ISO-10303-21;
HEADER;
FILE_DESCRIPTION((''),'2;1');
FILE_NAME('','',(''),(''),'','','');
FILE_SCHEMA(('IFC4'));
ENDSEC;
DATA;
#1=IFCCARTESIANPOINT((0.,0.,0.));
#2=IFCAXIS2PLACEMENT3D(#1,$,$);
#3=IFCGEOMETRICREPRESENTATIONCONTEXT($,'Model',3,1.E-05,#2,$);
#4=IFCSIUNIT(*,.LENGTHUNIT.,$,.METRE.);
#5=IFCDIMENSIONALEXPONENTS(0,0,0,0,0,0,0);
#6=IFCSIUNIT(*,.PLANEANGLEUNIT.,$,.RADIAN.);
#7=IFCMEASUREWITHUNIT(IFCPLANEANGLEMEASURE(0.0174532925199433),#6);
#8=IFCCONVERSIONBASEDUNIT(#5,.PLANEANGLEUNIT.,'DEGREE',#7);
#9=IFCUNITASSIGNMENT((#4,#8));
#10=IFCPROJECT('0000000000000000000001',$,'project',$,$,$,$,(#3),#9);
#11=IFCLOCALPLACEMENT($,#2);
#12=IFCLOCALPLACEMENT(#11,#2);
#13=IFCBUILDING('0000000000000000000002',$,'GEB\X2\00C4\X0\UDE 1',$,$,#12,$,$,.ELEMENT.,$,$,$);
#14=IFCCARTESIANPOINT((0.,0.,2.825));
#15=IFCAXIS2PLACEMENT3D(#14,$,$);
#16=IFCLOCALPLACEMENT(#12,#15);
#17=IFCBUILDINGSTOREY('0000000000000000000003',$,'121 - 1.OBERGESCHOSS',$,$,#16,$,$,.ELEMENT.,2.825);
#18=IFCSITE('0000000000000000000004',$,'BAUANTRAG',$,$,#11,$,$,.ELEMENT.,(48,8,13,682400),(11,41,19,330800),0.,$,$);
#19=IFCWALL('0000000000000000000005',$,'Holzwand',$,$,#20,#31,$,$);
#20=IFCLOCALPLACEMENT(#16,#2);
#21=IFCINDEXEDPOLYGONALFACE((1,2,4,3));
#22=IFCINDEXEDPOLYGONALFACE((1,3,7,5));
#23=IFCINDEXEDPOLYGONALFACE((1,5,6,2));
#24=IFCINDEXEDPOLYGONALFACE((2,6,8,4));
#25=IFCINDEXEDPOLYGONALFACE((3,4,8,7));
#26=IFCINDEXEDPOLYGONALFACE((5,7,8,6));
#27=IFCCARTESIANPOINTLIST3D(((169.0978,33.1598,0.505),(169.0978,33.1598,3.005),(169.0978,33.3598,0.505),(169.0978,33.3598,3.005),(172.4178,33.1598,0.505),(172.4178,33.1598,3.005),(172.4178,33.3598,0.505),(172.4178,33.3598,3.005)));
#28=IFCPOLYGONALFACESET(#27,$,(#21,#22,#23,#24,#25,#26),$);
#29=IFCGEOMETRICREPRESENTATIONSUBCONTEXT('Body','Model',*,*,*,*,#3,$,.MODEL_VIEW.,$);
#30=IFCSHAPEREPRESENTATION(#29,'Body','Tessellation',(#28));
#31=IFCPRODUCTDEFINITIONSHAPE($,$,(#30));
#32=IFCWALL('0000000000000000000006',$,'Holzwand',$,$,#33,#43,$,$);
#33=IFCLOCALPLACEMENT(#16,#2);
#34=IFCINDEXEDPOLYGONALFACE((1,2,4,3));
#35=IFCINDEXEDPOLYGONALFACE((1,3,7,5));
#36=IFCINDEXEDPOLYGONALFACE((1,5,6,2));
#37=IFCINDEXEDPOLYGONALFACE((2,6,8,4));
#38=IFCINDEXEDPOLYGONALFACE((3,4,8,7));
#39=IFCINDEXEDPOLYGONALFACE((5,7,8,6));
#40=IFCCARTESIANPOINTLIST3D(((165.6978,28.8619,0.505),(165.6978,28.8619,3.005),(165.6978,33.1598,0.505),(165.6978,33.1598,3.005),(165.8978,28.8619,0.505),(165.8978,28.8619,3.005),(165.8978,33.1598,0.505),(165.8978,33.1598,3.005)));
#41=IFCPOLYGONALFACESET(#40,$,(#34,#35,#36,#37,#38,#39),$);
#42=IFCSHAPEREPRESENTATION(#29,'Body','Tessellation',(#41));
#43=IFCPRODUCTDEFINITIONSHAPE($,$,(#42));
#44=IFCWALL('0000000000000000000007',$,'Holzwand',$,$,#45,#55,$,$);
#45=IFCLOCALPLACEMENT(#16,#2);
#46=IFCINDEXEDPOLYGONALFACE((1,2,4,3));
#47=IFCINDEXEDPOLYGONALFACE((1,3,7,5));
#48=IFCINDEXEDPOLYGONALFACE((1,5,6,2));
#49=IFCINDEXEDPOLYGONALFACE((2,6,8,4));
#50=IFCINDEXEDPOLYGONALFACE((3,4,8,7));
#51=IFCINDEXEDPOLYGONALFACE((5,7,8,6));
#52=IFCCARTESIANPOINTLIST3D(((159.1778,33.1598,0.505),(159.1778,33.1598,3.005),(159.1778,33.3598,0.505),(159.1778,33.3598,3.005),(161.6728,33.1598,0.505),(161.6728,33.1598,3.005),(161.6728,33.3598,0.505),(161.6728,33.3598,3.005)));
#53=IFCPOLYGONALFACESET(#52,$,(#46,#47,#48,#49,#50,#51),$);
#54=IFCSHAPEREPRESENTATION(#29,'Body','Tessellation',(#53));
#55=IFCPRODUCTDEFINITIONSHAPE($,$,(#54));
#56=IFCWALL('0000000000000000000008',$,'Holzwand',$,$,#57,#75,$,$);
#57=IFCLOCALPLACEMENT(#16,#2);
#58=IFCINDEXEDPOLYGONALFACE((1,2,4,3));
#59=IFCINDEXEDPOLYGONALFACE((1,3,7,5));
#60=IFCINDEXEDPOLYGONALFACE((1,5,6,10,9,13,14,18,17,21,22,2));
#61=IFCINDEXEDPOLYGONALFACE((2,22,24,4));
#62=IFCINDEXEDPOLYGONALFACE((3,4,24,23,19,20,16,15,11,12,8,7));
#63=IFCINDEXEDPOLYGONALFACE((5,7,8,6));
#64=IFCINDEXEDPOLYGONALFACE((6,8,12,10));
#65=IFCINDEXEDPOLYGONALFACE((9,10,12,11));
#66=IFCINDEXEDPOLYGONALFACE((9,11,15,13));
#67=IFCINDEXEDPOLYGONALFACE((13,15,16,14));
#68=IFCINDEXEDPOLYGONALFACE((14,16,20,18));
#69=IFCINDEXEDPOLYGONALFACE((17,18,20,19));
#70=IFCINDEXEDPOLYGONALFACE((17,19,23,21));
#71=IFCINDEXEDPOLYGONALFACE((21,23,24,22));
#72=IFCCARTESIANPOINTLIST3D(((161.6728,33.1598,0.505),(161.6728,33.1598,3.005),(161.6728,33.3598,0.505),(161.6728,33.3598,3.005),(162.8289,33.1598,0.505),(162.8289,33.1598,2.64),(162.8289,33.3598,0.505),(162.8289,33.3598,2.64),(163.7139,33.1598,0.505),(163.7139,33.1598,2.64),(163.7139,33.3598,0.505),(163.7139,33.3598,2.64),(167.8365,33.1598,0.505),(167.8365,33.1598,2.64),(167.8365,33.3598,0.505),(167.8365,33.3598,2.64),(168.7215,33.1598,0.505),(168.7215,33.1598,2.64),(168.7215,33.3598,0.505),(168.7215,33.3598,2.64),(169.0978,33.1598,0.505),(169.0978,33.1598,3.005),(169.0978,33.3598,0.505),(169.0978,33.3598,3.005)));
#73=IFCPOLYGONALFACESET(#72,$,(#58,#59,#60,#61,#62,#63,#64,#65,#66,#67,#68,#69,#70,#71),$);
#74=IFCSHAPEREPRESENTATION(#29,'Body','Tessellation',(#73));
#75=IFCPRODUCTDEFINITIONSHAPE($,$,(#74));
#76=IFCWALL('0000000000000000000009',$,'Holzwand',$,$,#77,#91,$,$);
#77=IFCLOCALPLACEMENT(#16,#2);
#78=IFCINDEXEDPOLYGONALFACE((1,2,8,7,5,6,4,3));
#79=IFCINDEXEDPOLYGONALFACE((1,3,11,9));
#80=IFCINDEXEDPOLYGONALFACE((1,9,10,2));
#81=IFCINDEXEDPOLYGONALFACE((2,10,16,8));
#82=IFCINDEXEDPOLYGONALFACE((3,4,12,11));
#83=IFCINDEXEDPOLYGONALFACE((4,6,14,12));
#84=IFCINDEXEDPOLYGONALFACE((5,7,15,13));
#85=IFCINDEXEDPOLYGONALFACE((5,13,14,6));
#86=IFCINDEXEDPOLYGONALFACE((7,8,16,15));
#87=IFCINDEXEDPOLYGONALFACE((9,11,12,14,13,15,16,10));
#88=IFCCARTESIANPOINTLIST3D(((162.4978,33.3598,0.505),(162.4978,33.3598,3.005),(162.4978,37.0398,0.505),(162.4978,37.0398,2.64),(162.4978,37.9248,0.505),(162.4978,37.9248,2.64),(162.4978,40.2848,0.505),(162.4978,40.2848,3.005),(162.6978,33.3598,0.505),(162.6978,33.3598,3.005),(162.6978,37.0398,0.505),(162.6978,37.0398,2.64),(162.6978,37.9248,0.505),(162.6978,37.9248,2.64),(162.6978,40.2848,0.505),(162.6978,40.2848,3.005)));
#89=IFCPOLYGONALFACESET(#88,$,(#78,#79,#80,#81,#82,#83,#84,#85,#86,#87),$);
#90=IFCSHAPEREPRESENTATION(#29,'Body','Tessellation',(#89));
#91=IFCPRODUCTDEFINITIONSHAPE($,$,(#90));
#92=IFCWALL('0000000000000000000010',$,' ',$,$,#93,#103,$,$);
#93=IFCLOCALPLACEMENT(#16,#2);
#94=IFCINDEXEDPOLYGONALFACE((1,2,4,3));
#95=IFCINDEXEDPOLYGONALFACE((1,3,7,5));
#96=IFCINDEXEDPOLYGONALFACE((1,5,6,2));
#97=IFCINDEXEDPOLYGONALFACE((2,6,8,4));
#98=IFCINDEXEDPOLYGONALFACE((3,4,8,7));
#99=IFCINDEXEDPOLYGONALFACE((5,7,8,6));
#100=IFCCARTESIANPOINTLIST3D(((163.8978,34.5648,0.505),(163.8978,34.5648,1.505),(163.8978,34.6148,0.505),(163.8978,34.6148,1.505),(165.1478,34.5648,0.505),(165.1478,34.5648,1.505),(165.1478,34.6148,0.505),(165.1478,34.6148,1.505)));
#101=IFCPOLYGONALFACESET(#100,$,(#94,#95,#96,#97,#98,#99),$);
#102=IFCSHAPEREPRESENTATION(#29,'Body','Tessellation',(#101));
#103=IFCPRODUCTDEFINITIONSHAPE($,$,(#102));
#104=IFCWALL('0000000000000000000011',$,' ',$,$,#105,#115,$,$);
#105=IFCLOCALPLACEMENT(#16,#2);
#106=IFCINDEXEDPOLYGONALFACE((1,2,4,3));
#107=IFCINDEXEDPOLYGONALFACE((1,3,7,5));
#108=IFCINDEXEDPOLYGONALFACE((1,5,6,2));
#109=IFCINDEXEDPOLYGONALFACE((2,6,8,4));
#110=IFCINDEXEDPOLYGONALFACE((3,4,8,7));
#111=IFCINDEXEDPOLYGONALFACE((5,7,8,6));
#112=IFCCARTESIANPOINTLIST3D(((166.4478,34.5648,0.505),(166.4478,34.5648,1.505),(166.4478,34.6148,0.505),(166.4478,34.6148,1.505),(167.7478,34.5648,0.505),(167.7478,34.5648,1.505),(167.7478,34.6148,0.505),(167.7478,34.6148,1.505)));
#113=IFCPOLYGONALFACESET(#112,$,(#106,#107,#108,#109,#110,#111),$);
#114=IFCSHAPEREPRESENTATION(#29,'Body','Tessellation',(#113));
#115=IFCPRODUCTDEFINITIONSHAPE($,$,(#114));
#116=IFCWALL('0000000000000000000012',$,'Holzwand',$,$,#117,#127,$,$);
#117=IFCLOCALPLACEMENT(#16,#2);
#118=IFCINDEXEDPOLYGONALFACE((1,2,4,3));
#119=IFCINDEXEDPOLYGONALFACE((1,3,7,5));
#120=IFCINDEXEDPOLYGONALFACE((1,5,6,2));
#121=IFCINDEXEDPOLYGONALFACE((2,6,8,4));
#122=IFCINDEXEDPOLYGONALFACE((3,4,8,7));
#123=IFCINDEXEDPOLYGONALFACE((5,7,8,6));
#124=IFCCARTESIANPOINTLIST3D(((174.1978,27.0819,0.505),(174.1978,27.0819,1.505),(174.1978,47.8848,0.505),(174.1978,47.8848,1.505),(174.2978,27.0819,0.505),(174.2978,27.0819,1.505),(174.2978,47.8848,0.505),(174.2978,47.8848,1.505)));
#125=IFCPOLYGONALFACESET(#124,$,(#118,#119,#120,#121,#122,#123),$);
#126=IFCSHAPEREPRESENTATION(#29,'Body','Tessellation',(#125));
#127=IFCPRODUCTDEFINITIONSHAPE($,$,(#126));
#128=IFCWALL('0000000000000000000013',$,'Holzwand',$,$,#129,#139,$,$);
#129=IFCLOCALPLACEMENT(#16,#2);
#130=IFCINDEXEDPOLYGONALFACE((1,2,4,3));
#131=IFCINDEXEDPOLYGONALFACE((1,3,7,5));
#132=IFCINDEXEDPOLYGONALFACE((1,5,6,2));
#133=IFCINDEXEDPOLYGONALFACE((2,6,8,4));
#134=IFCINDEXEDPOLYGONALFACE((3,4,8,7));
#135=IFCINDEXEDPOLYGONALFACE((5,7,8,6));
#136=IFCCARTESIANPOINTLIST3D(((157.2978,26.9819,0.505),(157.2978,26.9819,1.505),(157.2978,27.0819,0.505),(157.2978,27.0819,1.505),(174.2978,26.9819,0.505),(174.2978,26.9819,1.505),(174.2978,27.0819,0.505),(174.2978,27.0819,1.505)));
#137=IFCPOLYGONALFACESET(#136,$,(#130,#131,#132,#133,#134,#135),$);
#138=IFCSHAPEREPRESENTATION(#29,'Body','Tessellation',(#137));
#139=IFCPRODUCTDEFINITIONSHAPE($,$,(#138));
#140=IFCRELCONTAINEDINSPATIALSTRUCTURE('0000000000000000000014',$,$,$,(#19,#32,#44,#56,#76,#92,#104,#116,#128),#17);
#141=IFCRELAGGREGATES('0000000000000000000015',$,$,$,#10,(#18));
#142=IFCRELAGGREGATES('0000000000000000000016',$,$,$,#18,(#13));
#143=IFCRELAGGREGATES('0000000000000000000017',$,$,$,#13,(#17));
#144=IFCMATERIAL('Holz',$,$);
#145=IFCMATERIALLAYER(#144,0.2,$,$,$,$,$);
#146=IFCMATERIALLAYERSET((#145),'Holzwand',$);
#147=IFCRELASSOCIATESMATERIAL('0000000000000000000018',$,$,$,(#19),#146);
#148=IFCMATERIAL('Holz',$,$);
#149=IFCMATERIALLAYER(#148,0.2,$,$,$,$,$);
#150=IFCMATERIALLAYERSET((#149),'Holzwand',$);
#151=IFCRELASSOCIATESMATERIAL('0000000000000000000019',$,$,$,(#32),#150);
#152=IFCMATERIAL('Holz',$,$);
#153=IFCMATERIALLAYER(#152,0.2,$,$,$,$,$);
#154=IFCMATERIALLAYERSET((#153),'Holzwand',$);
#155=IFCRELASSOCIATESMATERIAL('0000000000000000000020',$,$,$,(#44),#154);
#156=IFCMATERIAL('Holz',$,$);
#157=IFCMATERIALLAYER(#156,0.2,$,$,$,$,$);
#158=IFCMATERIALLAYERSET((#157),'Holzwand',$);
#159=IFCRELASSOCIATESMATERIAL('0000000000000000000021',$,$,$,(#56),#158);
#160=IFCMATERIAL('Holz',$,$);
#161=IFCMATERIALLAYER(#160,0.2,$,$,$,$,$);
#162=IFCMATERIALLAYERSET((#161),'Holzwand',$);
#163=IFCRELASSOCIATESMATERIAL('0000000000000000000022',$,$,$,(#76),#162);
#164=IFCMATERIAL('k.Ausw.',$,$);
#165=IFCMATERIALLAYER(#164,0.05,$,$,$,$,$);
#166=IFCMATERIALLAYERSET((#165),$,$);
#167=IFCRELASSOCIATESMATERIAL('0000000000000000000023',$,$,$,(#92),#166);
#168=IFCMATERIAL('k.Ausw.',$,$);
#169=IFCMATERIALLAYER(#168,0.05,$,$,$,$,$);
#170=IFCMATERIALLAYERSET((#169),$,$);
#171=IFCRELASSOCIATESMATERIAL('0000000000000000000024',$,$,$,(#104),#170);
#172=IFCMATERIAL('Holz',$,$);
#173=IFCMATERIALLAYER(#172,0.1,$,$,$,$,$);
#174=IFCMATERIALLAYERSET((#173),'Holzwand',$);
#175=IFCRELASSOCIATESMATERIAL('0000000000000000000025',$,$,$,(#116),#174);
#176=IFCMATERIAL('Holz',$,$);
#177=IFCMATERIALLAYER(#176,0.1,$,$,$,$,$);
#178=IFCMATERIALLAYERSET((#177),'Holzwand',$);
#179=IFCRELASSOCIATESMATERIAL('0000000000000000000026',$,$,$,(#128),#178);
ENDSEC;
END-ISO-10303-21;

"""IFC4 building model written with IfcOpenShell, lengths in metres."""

from ifc_helpers import new_model, entity, si_unit, converted_unit, frame, frame_2d, origin, origin_with_axes, place, context, subcontext, project, spatial, polyline, rectangle, outline, extrude, material, layer, layer_set, layer_usage, element, save


model = new_model("IFC4")

# Units and contexts
model_context = context("Model", 3, precision=1e-05, world=origin())
body_context = subcontext(model_context, "Body", "Model", "MODEL_VIEW")
ifc_project = project(units=[si_unit("LENGTHUNIT", "METRE"), converted_unit("PLANEANGLEUNIT", "DEGREE", entity("IfcPlaneAngleMeasure", 0.0174532925199433), si_unit("PLANEANGLEUNIT", "RADIAN"), dimensions=[0, 0, 0, 0, 0, 0, 0])], contexts=[model_context])

# Site, building, storey
site_placement = place(None, origin())
site = spatial("IfcSite", under=ifc_project, at=site_placement, Name="BAUANTRAG", CompositionType="ELEMENT", RefLatitude=(48, 8, 13, 682400), RefLongitude=(11, 41, 19, 330800), RefElevation=0.0)
building_placement = place(site_placement, origin())
building = spatial("IfcBuilding", under=site, at=building_placement, Name="GEBÄUDE 1", CompositionType="ELEMENT")
storey_placement = place(building_placement, frame((0.0, 0.0, 2.825)))
storey = spatial("IfcBuildingStorey", under=building, at=storey_placement, Name="121 - 1.OBERGESCHOSS", CompositionType="ELEMENT", Elevation=2.825)

# Walls
ifc_material_1 = material(Name="Holz")
ifc_layer_1 = layer(ifc_material_1, 0.2)
ifc_layer_set_1 = layer_set([ifc_layer_1], Name="Holzwand")
ifc_layer_usage_1 = layer_usage(ifc_layer_set_1, "AXIS2", "POSITIVE", 0.0)
wall_1_placement = place(storey_placement, frame((169.0978, 33.1598, 0.505)))
element("IfcWall", 1, at=wall_1_placement, inside=storey, material=ifc_layer_usage_1, Name="Holzwand", context=body_context, shape_type="SweptSolid", body=[
    extrude(rectangle(XDim=3.32, YDim=0.2, at=frame_2d((1.66, 0.1), x_axis=(1.0, 0.0))), origin_with_axes(), (0.0, 0.0, 1.0), 2.5),
])
ifc_material_2 = material(Name="Holz")
ifc_layer_2 = layer(ifc_material_2, 0.2)
ifc_layer_set_2 = layer_set([ifc_layer_2], Name="Holzwand")
ifc_layer_usage_2 = layer_usage(ifc_layer_set_2, "AXIS2", "POSITIVE", 0.0)
wall_2_placement = place(storey_placement, frame((165.6978, 33.1598, 0.505), z_axis=(0.0, 0.0, 1.0), x_axis=(0.0, -1.0, 0.0)))
element("IfcWall", 2, at=wall_2_placement, inside=storey, material=ifc_layer_usage_2, Name="Holzwand", context=body_context, shape_type="SweptSolid", body=[
    extrude(rectangle(XDim=4.2979, YDim=0.2, at=frame_2d((2.1489, 0.1), x_axis=(1.0, 0.0))), origin_with_axes(), (0.0, 0.0, 1.0), 2.5),
])
ifc_material_3 = material(Name="Holz")
ifc_layer_3 = layer(ifc_material_3, 0.2)
ifc_layer_set_3 = layer_set([ifc_layer_3], Name="Holzwand")
ifc_layer_usage_3 = layer_usage(ifc_layer_set_3, "AXIS2", "POSITIVE", 0.0)
wall_3_placement = place(storey_placement, frame((159.1778, 33.1598, 0.505)))
element("IfcWall", 3, at=wall_3_placement, inside=storey, material=ifc_layer_usage_3, Name="Holzwand", context=body_context, shape_type="SweptSolid", body=[
    extrude(rectangle(XDim=2.495, YDim=0.2, at=frame_2d((1.2475, 0.1), x_axis=(1.0, 0.0))), origin_with_axes(), (0.0, 0.0, 1.0), 2.5),
])

# Wall, openings
ifc_material_4 = material(Name="Holz")
ifc_layer_4 = layer(ifc_material_4, 0.2)
ifc_layer_set_4 = layer_set([ifc_layer_4], Name="Holzwand")
ifc_layer_usage_4 = layer_usage(ifc_layer_set_4, "AXIS2", "POSITIVE", 0.0)
wall_4_placement = place(storey_placement, frame((169.0978, 33.3598, 0.505), z_axis=(0.0, 0.0, 1.0), x_axis=(-1.0, 0.0, 0.0)))
wall_4 = element("IfcWall", 4, at=wall_4_placement, inside=storey, material=ifc_layer_usage_4, Name="Holzwand", context=body_context, shape_type="SweptSolid", body=[
    extrude(rectangle(XDim=7.425, YDim=0.2, at=frame_2d((3.7125, 0.1), x_axis=(1.0, 0.0))), origin_with_axes(), (0.0, 0.0, 1.0), 2.5),
])
opening_1_placement = place(wall_4_placement, frame((1.2613, 0.2, -0.15), z_axis=(0.0, -1.0, 0.0), x_axis=(0.0, 0.0, 1.0)))
element("IfcOpeningElement", 5, at=opening_1_placement, cuts=wall_4, ObjectType="Opening", context=body_context, shape_type="SweptSolid", body=[
    extrude(outline(polyline([(0.0, 0.885), (2.285, 0.885), (2.285, 0.0), (0.0, 0.0), (0.0, 0.885)])), origin_with_axes(), (0.0, 0.0, 1.0), 0.2),
])
opening_2_placement = place(wall_4_placement, frame((6.2689, 0.2, -0.15), z_axis=(0.0, -1.0, 0.0), x_axis=(0.0, 0.0, 1.0)))
element("IfcOpeningElement", 6, at=opening_2_placement, cuts=wall_4, ObjectType="Opening", context=body_context, shape_type="SweptSolid", body=[
    extrude(outline(polyline([(0.0, 0.885), (2.285, 0.885), (2.285, 0.0), (0.0, 0.0), (0.0, 0.885)])), origin_with_axes(), (0.0, 0.0, 1.0), 0.2),
])

# Wall, opening
ifc_material_5 = material(Name="Holz")
ifc_layer_5 = layer(ifc_material_5, 0.2)
ifc_layer_set_5 = layer_set([ifc_layer_5], Name="Holzwand")
ifc_layer_usage_5 = layer_usage(ifc_layer_set_5, "AXIS2", "POSITIVE", 0.0)
wall_5_placement = place(storey_placement, frame((162.6978, 33.3598, 0.505), z_axis=(0.0, 0.0, 1.0), x_axis=(0.0, 1.0, 0.0)))
wall_5 = element("IfcWall", 7, at=wall_5_placement, inside=storey, material=ifc_layer_usage_5, Name="Holzwand", context=body_context, shape_type="SweptSolid", body=[
    extrude(rectangle(XDim=6.925, YDim=0.2, at=frame_2d((3.4625, 0.1), x_axis=(1.0, 0.0))), origin_with_axes(), (0.0, 0.0, 1.0), 2.5),
])
opening_3_placement = place(wall_5_placement, frame((3.68, 0.0, -0.15), z_axis=(0.0, 1.0, 0.0), x_axis=(0.0, 0.0, 1.0)))
element("IfcOpeningElement", 8, at=opening_3_placement, cuts=wall_5, ObjectType="Opening", context=body_context, shape_type="SweptSolid", body=[
    extrude(outline(polyline([(0.0, 0.885), (2.285, 0.885), (2.285, 0.0), (0.0, 0.0), (0.0, 0.885)])), origin_with_axes(), (0.0, 0.0, 1.0), 0.2),
])

# Walls
ifc_material_6 = material(Name="k.Ausw.")
ifc_layer_6 = layer(ifc_material_6, 0.05)
ifc_layer_set_6 = layer_set([ifc_layer_6])
ifc_layer_usage_6 = layer_usage(ifc_layer_set_6, "AXIS2", "POSITIVE", 0.0)
wall_6_placement = place(storey_placement, frame((163.8978, 34.5648, 0.505), z_axis=(0.0, 0.0, 1.0), x_axis=(1.0, 0.0, 0.0)))
element("IfcWall", 9, at=wall_6_placement, inside=storey, material=ifc_layer_usage_6, Name=" ", context=body_context, shape_type="SweptSolid", body=[
    extrude(rectangle(XDim=1.25, YDim=0.05, at=frame_2d((0.625, 0.025), x_axis=(1.0, 0.0))), origin_with_axes(), (0.0, 0.0, 1.0), 1.0),
])
ifc_material_7 = material(Name="k.Ausw.")
ifc_layer_7 = layer(ifc_material_7, 0.05)
ifc_layer_set_7 = layer_set([ifc_layer_7])
ifc_layer_usage_7 = layer_usage(ifc_layer_set_7, "AXIS2", "POSITIVE", 0.0)
wall_7_placement = place(storey_placement, frame((166.4478, 34.5648, 0.505), z_axis=(0.0, 0.0, 1.0), x_axis=(1.0, 0.0, 0.0)))
element("IfcWall", 10, at=wall_7_placement, inside=storey, material=ifc_layer_usage_7, Name=" ", context=body_context, shape_type="SweptSolid", body=[
    extrude(rectangle(XDim=1.3, YDim=0.05, at=frame_2d((0.65, 0.025), x_axis=(1.0, 0.0))), origin_with_axes(), (0.0, 0.0, 1.0), 1.0),
])
ifc_material_8 = material(Name="Holz")
ifc_layer_8 = layer(ifc_material_8, 0.1)
ifc_layer_set_8 = layer_set([ifc_layer_8], Name="Holzwand")
ifc_layer_usage_8 = layer_usage(ifc_layer_set_8, "AXIS2", "POSITIVE", 0.0)
wall_8_placement = place(storey_placement, frame((174.2978, 27.0819, 0.505), z_axis=(0.0, 0.0, 1.0), x_axis=(0.0, 1.0, 0.0)))
element("IfcWall", 11, at=wall_8_placement, inside=storey, material=ifc_layer_usage_8, Name="Holzwand", context=body_context, shape_type="SweptSolid", body=[
    extrude(rectangle(XDim=20.8029, YDim=0.1, at=frame_2d((10.4014, 0.05), x_axis=(1.0, 0.0))), origin_with_axes(), (0.0, 0.0, 1.0), 1.0),
])
ifc_material_9 = material(Name="Holz")
ifc_layer_9 = layer(ifc_material_9, 0.1)
ifc_layer_set_9 = layer_set([ifc_layer_9], Name="Holzwand")
ifc_layer_usage_9 = layer_usage(ifc_layer_set_9, "AXIS2", "POSITIVE", 0.0)
wall_9_placement = place(storey_placement, frame((157.2978, 26.9819, 0.505)))
element("IfcWall", 12, at=wall_9_placement, inside=storey, material=ifc_layer_usage_9, Name="Holzwand", context=body_context, shape_type="SweptSolid", body=[
    extrude(rectangle(XDim=17.0, YDim=0.1, at=frame_2d((8.5, 0.05), x_axis=(1.0, 0.0))), origin_with_axes(), (0.0, 0.0, 1.0), 1.0),
])

save(model, "model.ifc")
